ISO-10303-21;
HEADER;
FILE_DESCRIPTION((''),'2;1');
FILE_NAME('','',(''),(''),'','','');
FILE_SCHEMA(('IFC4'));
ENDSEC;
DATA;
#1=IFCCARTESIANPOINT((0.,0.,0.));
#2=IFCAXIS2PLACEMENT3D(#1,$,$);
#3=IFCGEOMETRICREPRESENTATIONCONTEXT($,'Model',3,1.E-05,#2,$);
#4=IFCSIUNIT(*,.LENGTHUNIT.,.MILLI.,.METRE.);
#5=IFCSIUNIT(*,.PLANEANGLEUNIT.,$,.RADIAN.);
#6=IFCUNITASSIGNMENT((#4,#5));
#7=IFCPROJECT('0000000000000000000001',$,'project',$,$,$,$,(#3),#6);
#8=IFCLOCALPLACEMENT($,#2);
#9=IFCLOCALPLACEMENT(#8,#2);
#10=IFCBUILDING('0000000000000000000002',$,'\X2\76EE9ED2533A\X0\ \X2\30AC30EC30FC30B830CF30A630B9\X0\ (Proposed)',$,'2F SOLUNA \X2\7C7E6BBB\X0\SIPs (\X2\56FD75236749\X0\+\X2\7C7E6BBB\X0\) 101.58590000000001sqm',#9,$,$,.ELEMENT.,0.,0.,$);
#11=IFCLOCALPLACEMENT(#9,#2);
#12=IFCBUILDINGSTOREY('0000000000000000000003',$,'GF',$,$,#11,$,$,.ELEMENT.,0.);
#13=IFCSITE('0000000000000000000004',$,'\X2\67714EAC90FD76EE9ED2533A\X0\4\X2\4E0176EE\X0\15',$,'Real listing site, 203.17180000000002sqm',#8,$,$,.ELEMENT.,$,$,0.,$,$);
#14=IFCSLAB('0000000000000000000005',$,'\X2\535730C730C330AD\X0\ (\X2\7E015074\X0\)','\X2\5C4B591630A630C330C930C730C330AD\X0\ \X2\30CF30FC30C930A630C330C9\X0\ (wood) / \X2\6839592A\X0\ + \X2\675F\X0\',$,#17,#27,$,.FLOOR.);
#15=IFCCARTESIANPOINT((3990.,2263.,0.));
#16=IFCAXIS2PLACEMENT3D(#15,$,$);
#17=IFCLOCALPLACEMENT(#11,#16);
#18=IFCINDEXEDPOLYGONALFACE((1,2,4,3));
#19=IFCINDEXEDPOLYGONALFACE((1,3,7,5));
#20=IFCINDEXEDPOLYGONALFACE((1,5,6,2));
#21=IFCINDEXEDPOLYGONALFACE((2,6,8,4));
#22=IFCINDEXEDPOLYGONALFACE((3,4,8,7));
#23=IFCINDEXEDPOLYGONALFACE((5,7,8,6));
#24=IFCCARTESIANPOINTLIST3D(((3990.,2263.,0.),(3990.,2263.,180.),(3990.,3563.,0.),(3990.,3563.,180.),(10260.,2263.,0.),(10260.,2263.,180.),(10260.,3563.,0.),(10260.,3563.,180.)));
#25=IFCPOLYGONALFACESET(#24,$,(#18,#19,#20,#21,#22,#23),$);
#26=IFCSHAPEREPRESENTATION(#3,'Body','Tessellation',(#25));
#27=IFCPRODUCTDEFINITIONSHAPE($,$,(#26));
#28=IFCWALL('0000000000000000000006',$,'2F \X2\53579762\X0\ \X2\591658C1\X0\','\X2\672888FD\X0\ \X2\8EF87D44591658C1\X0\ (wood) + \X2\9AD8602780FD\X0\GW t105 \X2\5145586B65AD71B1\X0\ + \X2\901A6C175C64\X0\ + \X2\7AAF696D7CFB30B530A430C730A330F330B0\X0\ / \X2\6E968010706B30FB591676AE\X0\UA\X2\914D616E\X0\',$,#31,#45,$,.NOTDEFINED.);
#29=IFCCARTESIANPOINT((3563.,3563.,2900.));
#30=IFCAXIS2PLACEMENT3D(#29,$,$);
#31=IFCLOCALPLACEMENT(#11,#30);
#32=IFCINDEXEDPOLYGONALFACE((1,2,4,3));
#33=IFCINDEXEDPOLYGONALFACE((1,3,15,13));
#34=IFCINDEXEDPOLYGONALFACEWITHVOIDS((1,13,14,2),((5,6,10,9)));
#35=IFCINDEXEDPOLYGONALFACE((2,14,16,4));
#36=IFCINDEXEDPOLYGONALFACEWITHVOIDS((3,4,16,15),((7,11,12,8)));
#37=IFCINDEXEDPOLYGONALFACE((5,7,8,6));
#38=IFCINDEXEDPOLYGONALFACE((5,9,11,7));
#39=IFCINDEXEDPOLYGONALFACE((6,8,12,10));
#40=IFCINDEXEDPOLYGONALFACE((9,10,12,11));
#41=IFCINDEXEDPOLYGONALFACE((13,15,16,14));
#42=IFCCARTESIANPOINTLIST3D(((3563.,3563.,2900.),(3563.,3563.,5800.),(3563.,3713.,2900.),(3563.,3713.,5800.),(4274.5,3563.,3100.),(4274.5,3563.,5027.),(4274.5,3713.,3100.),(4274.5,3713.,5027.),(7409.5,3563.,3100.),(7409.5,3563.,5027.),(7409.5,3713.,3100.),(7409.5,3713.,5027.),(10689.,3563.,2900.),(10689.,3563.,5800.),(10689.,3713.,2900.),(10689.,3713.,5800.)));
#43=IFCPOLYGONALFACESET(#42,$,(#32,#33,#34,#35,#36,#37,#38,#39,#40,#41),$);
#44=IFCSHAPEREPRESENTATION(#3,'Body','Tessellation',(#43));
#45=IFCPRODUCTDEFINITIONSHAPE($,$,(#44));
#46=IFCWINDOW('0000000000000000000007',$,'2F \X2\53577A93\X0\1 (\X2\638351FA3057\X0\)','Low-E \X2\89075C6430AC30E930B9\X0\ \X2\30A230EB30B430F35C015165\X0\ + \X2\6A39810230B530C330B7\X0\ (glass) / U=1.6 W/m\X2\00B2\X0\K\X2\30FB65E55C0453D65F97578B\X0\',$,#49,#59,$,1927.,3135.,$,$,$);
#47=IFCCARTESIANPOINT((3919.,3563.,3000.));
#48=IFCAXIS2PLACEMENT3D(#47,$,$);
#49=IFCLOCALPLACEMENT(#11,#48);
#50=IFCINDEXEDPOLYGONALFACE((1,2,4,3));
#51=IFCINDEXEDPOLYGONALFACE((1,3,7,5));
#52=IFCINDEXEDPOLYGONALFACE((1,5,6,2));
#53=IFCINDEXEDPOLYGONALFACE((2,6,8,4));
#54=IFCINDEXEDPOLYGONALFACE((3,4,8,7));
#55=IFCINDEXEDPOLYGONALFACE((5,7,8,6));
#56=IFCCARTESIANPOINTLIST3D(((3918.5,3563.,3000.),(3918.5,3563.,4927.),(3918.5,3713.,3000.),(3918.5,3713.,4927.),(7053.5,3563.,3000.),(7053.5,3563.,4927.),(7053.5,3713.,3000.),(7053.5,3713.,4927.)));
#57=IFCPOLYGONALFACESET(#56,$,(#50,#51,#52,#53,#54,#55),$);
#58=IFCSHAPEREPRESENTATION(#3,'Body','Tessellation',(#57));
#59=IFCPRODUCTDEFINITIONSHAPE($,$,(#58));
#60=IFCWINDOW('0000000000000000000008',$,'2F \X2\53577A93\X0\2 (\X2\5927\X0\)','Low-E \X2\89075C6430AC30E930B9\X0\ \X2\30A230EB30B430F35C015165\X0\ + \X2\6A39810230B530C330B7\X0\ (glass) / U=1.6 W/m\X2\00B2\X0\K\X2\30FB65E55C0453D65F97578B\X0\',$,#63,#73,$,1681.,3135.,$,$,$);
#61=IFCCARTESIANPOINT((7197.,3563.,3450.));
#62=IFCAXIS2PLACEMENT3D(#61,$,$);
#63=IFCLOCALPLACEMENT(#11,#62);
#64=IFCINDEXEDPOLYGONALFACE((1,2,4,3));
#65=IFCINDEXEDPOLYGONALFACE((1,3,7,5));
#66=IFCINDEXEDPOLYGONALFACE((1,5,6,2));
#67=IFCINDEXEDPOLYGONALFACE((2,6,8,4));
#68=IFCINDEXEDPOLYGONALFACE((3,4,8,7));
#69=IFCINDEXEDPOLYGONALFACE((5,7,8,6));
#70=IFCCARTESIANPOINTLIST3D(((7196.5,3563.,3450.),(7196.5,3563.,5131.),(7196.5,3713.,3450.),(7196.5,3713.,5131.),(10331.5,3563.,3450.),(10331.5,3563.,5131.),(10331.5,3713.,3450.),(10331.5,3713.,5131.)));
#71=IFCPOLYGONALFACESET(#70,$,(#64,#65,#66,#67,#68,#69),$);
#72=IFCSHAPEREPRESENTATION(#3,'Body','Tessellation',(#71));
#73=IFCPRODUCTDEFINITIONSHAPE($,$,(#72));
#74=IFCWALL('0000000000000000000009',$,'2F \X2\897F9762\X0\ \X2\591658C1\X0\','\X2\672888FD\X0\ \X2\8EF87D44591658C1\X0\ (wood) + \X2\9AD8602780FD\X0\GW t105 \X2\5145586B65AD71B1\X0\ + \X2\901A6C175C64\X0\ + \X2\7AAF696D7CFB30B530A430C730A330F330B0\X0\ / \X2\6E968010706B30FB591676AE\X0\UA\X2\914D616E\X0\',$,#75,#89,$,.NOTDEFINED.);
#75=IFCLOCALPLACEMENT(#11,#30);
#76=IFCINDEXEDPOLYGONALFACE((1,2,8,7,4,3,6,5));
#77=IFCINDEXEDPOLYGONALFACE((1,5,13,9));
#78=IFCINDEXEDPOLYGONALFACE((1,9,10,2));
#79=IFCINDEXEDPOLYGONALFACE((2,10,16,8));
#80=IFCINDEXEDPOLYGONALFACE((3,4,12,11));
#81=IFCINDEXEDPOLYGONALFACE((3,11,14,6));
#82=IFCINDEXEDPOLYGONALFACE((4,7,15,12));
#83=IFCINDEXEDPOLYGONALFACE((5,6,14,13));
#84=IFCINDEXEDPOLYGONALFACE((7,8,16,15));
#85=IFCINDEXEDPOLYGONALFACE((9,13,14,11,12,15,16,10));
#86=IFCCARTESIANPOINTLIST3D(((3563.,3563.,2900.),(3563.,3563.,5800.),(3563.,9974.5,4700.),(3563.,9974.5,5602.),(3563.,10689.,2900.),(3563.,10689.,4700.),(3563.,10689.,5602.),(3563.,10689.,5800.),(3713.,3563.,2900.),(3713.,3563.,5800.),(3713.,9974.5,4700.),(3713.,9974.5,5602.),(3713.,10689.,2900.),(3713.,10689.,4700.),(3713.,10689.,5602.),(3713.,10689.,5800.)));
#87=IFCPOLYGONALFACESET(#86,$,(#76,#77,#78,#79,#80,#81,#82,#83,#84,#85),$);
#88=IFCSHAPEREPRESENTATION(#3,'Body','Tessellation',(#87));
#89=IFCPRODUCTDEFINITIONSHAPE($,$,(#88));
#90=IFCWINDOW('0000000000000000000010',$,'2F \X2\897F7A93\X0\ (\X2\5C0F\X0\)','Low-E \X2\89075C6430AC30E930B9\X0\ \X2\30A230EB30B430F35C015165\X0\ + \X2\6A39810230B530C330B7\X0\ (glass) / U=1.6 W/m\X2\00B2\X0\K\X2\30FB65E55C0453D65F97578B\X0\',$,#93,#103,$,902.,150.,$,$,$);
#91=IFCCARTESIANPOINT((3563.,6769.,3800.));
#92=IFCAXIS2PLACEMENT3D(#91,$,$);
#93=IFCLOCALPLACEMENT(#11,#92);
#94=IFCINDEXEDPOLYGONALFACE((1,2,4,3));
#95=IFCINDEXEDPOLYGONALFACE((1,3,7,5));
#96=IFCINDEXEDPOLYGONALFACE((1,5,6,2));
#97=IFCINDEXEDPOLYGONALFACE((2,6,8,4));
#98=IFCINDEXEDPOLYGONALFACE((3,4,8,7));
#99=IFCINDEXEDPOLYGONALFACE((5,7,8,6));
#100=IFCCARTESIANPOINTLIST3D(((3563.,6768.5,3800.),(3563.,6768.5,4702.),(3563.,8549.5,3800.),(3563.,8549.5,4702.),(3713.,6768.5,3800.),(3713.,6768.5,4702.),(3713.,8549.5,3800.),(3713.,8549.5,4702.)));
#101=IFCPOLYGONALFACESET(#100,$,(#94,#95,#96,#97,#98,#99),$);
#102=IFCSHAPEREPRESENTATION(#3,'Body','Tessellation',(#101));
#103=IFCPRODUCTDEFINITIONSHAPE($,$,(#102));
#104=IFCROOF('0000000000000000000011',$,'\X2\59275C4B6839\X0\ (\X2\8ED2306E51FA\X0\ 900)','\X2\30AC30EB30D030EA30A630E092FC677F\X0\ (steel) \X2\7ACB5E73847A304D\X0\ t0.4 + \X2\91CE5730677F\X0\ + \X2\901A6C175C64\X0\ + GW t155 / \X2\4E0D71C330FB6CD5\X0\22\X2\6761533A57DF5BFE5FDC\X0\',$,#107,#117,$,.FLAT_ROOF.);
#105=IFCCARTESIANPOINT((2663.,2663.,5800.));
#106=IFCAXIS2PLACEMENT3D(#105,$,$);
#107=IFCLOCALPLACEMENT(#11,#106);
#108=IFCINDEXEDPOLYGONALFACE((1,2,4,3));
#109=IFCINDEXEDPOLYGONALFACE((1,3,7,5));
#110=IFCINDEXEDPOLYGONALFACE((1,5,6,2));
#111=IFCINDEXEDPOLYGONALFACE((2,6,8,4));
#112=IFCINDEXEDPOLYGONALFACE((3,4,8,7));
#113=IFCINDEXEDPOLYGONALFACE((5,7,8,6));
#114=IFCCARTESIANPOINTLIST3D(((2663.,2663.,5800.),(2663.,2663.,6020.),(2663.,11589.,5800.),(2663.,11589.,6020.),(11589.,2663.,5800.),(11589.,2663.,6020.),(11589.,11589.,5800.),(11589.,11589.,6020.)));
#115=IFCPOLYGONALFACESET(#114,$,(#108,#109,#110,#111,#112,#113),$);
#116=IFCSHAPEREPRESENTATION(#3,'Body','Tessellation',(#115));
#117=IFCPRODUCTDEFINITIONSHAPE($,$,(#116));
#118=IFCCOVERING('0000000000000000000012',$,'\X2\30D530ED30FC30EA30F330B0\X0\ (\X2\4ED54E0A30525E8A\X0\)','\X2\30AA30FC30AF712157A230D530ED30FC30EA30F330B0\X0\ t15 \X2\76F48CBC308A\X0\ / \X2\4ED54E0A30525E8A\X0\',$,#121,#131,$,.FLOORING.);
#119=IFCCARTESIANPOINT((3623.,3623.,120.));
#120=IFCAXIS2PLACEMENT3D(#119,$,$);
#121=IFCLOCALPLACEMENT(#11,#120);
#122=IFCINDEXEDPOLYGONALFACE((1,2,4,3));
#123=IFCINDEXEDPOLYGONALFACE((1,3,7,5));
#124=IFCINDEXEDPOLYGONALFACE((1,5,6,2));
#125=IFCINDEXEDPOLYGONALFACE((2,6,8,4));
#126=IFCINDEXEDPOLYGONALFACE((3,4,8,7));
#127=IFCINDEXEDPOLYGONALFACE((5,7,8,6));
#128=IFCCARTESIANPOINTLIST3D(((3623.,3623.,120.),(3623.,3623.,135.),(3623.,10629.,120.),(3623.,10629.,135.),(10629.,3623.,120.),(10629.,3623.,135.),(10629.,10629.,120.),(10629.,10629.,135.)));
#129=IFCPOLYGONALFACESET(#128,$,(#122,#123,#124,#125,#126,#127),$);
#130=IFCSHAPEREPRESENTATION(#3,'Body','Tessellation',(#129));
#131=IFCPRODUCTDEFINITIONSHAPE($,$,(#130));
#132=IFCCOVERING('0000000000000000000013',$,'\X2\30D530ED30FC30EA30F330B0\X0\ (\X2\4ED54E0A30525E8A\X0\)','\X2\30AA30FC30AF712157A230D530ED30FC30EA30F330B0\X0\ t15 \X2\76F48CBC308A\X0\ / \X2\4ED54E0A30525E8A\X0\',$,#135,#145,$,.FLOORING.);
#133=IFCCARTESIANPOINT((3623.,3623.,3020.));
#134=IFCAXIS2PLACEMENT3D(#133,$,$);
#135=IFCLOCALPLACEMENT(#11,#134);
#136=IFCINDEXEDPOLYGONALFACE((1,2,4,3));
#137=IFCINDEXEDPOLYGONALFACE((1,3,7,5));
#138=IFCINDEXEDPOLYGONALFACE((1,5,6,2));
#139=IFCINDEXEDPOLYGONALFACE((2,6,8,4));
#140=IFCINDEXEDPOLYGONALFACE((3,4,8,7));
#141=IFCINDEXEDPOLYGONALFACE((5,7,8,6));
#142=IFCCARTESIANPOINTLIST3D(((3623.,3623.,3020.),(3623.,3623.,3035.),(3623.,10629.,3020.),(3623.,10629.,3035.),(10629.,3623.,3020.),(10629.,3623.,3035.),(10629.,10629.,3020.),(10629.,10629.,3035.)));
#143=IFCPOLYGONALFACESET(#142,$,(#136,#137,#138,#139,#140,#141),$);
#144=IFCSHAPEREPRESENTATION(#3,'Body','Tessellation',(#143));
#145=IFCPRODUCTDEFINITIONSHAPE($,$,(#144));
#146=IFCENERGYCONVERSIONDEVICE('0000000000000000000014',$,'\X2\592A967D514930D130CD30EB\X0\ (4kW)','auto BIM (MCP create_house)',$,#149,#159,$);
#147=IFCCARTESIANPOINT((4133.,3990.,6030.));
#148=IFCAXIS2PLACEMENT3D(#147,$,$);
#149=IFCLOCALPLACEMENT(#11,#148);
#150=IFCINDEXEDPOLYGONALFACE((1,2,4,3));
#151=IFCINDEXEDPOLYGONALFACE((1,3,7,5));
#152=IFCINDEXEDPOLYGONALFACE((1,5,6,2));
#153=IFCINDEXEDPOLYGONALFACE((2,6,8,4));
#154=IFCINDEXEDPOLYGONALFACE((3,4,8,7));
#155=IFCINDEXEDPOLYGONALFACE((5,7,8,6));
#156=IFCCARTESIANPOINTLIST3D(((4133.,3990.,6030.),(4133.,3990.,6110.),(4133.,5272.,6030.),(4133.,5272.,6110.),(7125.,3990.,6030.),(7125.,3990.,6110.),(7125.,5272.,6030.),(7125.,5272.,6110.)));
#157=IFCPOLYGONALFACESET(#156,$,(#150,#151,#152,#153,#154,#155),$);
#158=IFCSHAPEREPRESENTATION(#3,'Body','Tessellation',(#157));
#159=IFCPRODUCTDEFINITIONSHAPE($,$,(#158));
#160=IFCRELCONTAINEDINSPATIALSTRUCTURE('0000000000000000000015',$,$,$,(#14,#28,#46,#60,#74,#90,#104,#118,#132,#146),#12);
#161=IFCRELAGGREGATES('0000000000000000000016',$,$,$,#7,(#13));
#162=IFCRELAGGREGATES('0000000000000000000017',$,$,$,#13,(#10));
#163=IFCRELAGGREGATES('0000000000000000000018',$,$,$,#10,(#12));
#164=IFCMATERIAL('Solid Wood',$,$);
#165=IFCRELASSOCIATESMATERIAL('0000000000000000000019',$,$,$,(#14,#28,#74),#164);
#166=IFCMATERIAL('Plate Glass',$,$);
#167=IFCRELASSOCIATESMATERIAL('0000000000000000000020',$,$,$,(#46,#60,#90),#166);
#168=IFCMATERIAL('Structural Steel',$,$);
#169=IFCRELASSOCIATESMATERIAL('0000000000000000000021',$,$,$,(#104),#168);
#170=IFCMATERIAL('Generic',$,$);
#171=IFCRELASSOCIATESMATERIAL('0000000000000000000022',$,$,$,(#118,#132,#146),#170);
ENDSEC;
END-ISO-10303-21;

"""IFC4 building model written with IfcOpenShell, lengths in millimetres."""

from ifc_helpers import new_model, si_unit, frame, frame_2d, origin, place, context, project, spatial, rectangle, extrude, material, element, fill, save


model = new_model("IFC4")

# Units and contexts
model_context = context("Model", 3, precision=1e-05, world=origin())
ifc_project = project(units=[si_unit("LENGTHUNIT", "METRE", prefix="MILLI"), si_unit("PLANEANGLEUNIT", "RADIAN")], contexts=[model_context])

# Site, building, storey
site_placement = place(None, origin())
site = spatial("IfcSite", under=ifc_project, at=site_placement, Name="東京都目黒区4丁目15", ObjectType="Real listing site, 203.17180000000002sqm", CompositionType="ELEMENT", RefElevation=0.0)
building_placement = place(site_placement, origin())
building = spatial("IfcBuilding", under=site, at=building_placement, Name="目黒区 ガレージハウス (Proposed)", ObjectType="2F SOLUNA 籾殻SIPs (国産杉+籾殻) 101.58590000000001sqm", CompositionType="ELEMENT", ElevationOfRefHeight=0.0, ElevationOfTerrain=0.0)
storey_placement = place(building_placement, origin())
storey = spatial("IfcBuildingStorey", under=building, at=storey_placement, Name="GF", CompositionType="ELEMENT", Elevation=0.0)

# Slab
ifc_material_1 = material(Name="Solid Wood")
slab_1_placement = place(storey_placement, frame((3990.0, 2263.0, 0.0)))
element("IfcSlab", 1, at=slab_1_placement, inside=storey, material=ifc_material_1, Name="南デッキ (縁側)", Description="屋外ウッドデッキ ハードウッド (wood) / 根太 + 束", PredefinedType="FLOOR", context=model_context, shape_type="SweptSolid", body=[
    extrude(rectangle(XDim=6270.0, YDim=1300.0, at=frame_2d((3135.0, 650.0))), frame((3990.0, 2263.0, 0.0)), (0.0, 0.0, 1.0), 180.0),
])

# Shared definitions
ifc_material_2 = material(Name="Plate Glass")

# Wall, openings, windows
wall_1_placement = place(storey_placement, frame((3563.0, 3563.0, 2900.0)))
wall_1 = element("IfcWall", 2, at=wall_1_placement, inside=storey, material=ifc_material_1, Name="2F 南面 外壁", Description="木製 軸組外壁 (wood) + 高性能GW t105 充填断熱 + 通気層 + 窯業系サイディング / 準耐火・外皮UA配慮", PredefinedType="NOTDEFINED", context=model_context, shape_type="SweptSolid", body=[
    extrude(rectangle(XDim=7126.0, YDim=150.0, at=frame_2d((3563.0, 75.0))), frame((3563.0, 3563.0, 2900.0)), (0.0, 0.0, 1.0), 2900.0),
])
opening_1_placement = place(storey_placement, frame((3919.0, 3563.0, 3000.0)))
opening_1 = element("IfcOpeningElement", 3, at=opening_1_placement, cuts=wall_1, PredefinedType="NOTDEFINED", context=model_context, shape_type="SweptSolid", body=[
    extrude(rectangle(XDim=3135.0, YDim=150.0, at=frame_2d((1567.0, 75.0))), frame((3919.0, 3563.0, 3000.0)), (0.0, 0.0, 1.0), 1927.0),
])
opening_2_placement = place(storey_placement, frame((7197.0, 3563.0, 3450.0)))
opening_2 = element("IfcOpeningElement", 4, at=opening_2_placement, cuts=wall_1, PredefinedType="NOTDEFINED", context=model_context, shape_type="SweptSolid", body=[
    extrude(rectangle(XDim=3135.0, YDim=150.0, at=frame_2d((1567.0, 75.0))), frame((7197.0, 3563.0, 3450.0)), (0.0, 0.0, 1.0), 1681.0),
])
window_1_placement = place(storey_placement, frame((3919.0, 3563.0, 3000.0)))
window_1 = element("IfcWindow", 5, at=window_1_placement, inside=storey, material=ifc_material_2, Name="2F 南窓1 (掃出し)", Description="Low-E 複層ガラス アルゴン封入 + 樹脂サッシ (glass) / U=1.6 W/m²K・日射取得型", OverallHeight=1927.0, OverallWidth=3135.0, context=model_context, shape_type="SweptSolid", body=[
    extrude(rectangle(XDim=3135.0, YDim=150.0, at=frame_2d((1567.0, 75.0))), frame((3919.0, 3563.0, 3000.0)), (0.0, 0.0, 1.0), 1927.0),
])
fill(opening_1, window_1)
window_2_placement = place(storey_placement, frame((7197.0, 3563.0, 3450.0)))
window_2 = element("IfcWindow", 6, at=window_2_placement, inside=storey, material=ifc_material_2, Name="2F 南窓2 (大)", Description="Low-E 複層ガラス アルゴン封入 + 樹脂サッシ (glass) / U=1.6 W/m²K・日射取得型", OverallHeight=1681.0, OverallWidth=3135.0, context=model_context, shape_type="SweptSolid", body=[
    extrude(rectangle(XDim=3135.0, YDim=150.0, at=frame_2d((1567.0, 75.0))), frame((7197.0, 3563.0, 3450.0)), (0.0, 0.0, 1.0), 1681.0),
])
fill(opening_2, window_2)

# Wall, opening, window
wall_2_placement = place(storey_placement, frame((3563.0, 3563.0, 2900.0)))
wall_2 = element("IfcWall", 7, at=wall_2_placement, inside=storey, material=ifc_material_1, Name="2F 西面 外壁", Description="木製 軸組外壁 (wood) + 高性能GW t105 充填断熱 + 通気層 + 窯業系サイディング / 準耐火・外皮UA配慮", PredefinedType="NOTDEFINED", context=model_context, shape_type="SweptSolid", body=[
    extrude(rectangle(XDim=150.0, YDim=7126.0, at=frame_2d((75.0, 3563.0))), frame((3563.0, 3563.0, 2900.0)), (0.0, 0.0, 1.0), 2900.0),
])
opening_3_placement = place(storey_placement, frame((3563.0, 6769.0, 3800.0)))
opening_3 = element("IfcOpeningElement", 8, at=opening_3_placement, cuts=wall_2, PredefinedType="NOTDEFINED", context=model_context, shape_type="SweptSolid", body=[
    extrude(rectangle(XDim=150.0, YDim=1781.0, at=frame_2d((75.0, 890.0))), frame((3563.0, 6769.0, 3800.0)), (0.0, 0.0, 1.0), 902.0),
])
window_3_placement = place(storey_placement, frame((3563.0, 6769.0, 3800.0)))
window_3 = element("IfcWindow", 9, at=window_3_placement, inside=storey, material=ifc_material_2, Name="2F 西窓 (小)", Description="Low-E 複層ガラス アルゴン封入 + 樹脂サッシ (glass) / U=1.6 W/m²K・日射取得型", OverallHeight=902.0, OverallWidth=150.0, context=model_context, shape_type="SweptSolid", body=[
    extrude(rectangle(XDim=150.0, YDim=1781.0, at=frame_2d((75.0, 890.0))), frame((3563.0, 6769.0, 3800.0)), (0.0, 0.0, 1.0), 902.0),
])
fill(opening_3, window_3)

# Roof
ifc_material_3 = material(Name="Structural Steel")
roof_placement = place(storey_placement, frame((2663.0, 2663.0, 5800.0)))
element("IfcRoof", 10, at=roof_placement, inside=storey, material=ifc_material_3, Name="大屋根 (軒の出 900)", Description="ガルバリウム鋼板 (steel) 立平葺き t0.4 + 野地板 + 通気層 + GW t155 / 不燃・法22条区域対応", PredefinedType="FLAT_ROOF", context=model_context, shape_type="SweptSolid", body=[
    extrude(rectangle(XDim=8926.0, YDim=8926.0, at=frame_2d((4463.0, 4463.0))), frame((2663.0, 2663.0, 5800.0)), (0.0, 0.0, 1.0), 220.0),
])

# Coverings
ifc_material_4 = material(Name="Generic")
covering_1_placement = place(storey_placement, frame((3623.0, 3623.0, 120.0)))
element("IfcCovering", 11, at=covering_1_placement, inside=storey, material=ifc_material_4, Name="フローリング (仕上げ床)", Description="オーク無垢フローリング t15 直貼り / 仕上げ床", PredefinedType="FLOORING", context=model_context, shape_type="SweptSolid", body=[
    extrude(rectangle(XDim=7006.0, YDim=7006.0, at=frame_2d((3503.0, 3503.0))), frame((3623.0, 3623.0, 120.0)), (0.0, 0.0, 1.0), 15.0),
])
covering_2_placement = place(storey_placement, frame((3623.0, 3623.0, 3020.0)))
element("IfcCovering", 12, at=covering_2_placement, inside=storey, material=ifc_material_4, Name="フローリング (仕上げ床)", Description="オーク無垢フローリング t15 直貼り / 仕上げ床", PredefinedType="FLOORING", context=model_context, shape_type="SweptSolid", body=[
    extrude(rectangle(XDim=7006.0, YDim=7006.0, at=frame_2d((3503.0, 3503.0))), frame((3623.0, 3623.0, 3020.0)), (0.0, 0.0, 1.0), 15.0),
])

# Energy conversion device
energy_conversion_device_placement = place(storey_placement, frame((4133.0, 3990.0, 6030.0)))
element("IfcEnergyConversionDevice", 13, at=energy_conversion_device_placement, inside=storey, material=ifc_material_4, Name="太陽光パネル (4kW)", Description="auto BIM (MCP create_house)", context=model_context, shape_type="SweptSolid", body=[
    extrude(rectangle(XDim=2992.0, YDim=1282.0, at=frame_2d((1496.0, 641.0))), frame((4133.0, 3990.0, 6030.0)), (0.0, 0.0, 1.0), 80.0),
])

save(model, "model.ifc")
